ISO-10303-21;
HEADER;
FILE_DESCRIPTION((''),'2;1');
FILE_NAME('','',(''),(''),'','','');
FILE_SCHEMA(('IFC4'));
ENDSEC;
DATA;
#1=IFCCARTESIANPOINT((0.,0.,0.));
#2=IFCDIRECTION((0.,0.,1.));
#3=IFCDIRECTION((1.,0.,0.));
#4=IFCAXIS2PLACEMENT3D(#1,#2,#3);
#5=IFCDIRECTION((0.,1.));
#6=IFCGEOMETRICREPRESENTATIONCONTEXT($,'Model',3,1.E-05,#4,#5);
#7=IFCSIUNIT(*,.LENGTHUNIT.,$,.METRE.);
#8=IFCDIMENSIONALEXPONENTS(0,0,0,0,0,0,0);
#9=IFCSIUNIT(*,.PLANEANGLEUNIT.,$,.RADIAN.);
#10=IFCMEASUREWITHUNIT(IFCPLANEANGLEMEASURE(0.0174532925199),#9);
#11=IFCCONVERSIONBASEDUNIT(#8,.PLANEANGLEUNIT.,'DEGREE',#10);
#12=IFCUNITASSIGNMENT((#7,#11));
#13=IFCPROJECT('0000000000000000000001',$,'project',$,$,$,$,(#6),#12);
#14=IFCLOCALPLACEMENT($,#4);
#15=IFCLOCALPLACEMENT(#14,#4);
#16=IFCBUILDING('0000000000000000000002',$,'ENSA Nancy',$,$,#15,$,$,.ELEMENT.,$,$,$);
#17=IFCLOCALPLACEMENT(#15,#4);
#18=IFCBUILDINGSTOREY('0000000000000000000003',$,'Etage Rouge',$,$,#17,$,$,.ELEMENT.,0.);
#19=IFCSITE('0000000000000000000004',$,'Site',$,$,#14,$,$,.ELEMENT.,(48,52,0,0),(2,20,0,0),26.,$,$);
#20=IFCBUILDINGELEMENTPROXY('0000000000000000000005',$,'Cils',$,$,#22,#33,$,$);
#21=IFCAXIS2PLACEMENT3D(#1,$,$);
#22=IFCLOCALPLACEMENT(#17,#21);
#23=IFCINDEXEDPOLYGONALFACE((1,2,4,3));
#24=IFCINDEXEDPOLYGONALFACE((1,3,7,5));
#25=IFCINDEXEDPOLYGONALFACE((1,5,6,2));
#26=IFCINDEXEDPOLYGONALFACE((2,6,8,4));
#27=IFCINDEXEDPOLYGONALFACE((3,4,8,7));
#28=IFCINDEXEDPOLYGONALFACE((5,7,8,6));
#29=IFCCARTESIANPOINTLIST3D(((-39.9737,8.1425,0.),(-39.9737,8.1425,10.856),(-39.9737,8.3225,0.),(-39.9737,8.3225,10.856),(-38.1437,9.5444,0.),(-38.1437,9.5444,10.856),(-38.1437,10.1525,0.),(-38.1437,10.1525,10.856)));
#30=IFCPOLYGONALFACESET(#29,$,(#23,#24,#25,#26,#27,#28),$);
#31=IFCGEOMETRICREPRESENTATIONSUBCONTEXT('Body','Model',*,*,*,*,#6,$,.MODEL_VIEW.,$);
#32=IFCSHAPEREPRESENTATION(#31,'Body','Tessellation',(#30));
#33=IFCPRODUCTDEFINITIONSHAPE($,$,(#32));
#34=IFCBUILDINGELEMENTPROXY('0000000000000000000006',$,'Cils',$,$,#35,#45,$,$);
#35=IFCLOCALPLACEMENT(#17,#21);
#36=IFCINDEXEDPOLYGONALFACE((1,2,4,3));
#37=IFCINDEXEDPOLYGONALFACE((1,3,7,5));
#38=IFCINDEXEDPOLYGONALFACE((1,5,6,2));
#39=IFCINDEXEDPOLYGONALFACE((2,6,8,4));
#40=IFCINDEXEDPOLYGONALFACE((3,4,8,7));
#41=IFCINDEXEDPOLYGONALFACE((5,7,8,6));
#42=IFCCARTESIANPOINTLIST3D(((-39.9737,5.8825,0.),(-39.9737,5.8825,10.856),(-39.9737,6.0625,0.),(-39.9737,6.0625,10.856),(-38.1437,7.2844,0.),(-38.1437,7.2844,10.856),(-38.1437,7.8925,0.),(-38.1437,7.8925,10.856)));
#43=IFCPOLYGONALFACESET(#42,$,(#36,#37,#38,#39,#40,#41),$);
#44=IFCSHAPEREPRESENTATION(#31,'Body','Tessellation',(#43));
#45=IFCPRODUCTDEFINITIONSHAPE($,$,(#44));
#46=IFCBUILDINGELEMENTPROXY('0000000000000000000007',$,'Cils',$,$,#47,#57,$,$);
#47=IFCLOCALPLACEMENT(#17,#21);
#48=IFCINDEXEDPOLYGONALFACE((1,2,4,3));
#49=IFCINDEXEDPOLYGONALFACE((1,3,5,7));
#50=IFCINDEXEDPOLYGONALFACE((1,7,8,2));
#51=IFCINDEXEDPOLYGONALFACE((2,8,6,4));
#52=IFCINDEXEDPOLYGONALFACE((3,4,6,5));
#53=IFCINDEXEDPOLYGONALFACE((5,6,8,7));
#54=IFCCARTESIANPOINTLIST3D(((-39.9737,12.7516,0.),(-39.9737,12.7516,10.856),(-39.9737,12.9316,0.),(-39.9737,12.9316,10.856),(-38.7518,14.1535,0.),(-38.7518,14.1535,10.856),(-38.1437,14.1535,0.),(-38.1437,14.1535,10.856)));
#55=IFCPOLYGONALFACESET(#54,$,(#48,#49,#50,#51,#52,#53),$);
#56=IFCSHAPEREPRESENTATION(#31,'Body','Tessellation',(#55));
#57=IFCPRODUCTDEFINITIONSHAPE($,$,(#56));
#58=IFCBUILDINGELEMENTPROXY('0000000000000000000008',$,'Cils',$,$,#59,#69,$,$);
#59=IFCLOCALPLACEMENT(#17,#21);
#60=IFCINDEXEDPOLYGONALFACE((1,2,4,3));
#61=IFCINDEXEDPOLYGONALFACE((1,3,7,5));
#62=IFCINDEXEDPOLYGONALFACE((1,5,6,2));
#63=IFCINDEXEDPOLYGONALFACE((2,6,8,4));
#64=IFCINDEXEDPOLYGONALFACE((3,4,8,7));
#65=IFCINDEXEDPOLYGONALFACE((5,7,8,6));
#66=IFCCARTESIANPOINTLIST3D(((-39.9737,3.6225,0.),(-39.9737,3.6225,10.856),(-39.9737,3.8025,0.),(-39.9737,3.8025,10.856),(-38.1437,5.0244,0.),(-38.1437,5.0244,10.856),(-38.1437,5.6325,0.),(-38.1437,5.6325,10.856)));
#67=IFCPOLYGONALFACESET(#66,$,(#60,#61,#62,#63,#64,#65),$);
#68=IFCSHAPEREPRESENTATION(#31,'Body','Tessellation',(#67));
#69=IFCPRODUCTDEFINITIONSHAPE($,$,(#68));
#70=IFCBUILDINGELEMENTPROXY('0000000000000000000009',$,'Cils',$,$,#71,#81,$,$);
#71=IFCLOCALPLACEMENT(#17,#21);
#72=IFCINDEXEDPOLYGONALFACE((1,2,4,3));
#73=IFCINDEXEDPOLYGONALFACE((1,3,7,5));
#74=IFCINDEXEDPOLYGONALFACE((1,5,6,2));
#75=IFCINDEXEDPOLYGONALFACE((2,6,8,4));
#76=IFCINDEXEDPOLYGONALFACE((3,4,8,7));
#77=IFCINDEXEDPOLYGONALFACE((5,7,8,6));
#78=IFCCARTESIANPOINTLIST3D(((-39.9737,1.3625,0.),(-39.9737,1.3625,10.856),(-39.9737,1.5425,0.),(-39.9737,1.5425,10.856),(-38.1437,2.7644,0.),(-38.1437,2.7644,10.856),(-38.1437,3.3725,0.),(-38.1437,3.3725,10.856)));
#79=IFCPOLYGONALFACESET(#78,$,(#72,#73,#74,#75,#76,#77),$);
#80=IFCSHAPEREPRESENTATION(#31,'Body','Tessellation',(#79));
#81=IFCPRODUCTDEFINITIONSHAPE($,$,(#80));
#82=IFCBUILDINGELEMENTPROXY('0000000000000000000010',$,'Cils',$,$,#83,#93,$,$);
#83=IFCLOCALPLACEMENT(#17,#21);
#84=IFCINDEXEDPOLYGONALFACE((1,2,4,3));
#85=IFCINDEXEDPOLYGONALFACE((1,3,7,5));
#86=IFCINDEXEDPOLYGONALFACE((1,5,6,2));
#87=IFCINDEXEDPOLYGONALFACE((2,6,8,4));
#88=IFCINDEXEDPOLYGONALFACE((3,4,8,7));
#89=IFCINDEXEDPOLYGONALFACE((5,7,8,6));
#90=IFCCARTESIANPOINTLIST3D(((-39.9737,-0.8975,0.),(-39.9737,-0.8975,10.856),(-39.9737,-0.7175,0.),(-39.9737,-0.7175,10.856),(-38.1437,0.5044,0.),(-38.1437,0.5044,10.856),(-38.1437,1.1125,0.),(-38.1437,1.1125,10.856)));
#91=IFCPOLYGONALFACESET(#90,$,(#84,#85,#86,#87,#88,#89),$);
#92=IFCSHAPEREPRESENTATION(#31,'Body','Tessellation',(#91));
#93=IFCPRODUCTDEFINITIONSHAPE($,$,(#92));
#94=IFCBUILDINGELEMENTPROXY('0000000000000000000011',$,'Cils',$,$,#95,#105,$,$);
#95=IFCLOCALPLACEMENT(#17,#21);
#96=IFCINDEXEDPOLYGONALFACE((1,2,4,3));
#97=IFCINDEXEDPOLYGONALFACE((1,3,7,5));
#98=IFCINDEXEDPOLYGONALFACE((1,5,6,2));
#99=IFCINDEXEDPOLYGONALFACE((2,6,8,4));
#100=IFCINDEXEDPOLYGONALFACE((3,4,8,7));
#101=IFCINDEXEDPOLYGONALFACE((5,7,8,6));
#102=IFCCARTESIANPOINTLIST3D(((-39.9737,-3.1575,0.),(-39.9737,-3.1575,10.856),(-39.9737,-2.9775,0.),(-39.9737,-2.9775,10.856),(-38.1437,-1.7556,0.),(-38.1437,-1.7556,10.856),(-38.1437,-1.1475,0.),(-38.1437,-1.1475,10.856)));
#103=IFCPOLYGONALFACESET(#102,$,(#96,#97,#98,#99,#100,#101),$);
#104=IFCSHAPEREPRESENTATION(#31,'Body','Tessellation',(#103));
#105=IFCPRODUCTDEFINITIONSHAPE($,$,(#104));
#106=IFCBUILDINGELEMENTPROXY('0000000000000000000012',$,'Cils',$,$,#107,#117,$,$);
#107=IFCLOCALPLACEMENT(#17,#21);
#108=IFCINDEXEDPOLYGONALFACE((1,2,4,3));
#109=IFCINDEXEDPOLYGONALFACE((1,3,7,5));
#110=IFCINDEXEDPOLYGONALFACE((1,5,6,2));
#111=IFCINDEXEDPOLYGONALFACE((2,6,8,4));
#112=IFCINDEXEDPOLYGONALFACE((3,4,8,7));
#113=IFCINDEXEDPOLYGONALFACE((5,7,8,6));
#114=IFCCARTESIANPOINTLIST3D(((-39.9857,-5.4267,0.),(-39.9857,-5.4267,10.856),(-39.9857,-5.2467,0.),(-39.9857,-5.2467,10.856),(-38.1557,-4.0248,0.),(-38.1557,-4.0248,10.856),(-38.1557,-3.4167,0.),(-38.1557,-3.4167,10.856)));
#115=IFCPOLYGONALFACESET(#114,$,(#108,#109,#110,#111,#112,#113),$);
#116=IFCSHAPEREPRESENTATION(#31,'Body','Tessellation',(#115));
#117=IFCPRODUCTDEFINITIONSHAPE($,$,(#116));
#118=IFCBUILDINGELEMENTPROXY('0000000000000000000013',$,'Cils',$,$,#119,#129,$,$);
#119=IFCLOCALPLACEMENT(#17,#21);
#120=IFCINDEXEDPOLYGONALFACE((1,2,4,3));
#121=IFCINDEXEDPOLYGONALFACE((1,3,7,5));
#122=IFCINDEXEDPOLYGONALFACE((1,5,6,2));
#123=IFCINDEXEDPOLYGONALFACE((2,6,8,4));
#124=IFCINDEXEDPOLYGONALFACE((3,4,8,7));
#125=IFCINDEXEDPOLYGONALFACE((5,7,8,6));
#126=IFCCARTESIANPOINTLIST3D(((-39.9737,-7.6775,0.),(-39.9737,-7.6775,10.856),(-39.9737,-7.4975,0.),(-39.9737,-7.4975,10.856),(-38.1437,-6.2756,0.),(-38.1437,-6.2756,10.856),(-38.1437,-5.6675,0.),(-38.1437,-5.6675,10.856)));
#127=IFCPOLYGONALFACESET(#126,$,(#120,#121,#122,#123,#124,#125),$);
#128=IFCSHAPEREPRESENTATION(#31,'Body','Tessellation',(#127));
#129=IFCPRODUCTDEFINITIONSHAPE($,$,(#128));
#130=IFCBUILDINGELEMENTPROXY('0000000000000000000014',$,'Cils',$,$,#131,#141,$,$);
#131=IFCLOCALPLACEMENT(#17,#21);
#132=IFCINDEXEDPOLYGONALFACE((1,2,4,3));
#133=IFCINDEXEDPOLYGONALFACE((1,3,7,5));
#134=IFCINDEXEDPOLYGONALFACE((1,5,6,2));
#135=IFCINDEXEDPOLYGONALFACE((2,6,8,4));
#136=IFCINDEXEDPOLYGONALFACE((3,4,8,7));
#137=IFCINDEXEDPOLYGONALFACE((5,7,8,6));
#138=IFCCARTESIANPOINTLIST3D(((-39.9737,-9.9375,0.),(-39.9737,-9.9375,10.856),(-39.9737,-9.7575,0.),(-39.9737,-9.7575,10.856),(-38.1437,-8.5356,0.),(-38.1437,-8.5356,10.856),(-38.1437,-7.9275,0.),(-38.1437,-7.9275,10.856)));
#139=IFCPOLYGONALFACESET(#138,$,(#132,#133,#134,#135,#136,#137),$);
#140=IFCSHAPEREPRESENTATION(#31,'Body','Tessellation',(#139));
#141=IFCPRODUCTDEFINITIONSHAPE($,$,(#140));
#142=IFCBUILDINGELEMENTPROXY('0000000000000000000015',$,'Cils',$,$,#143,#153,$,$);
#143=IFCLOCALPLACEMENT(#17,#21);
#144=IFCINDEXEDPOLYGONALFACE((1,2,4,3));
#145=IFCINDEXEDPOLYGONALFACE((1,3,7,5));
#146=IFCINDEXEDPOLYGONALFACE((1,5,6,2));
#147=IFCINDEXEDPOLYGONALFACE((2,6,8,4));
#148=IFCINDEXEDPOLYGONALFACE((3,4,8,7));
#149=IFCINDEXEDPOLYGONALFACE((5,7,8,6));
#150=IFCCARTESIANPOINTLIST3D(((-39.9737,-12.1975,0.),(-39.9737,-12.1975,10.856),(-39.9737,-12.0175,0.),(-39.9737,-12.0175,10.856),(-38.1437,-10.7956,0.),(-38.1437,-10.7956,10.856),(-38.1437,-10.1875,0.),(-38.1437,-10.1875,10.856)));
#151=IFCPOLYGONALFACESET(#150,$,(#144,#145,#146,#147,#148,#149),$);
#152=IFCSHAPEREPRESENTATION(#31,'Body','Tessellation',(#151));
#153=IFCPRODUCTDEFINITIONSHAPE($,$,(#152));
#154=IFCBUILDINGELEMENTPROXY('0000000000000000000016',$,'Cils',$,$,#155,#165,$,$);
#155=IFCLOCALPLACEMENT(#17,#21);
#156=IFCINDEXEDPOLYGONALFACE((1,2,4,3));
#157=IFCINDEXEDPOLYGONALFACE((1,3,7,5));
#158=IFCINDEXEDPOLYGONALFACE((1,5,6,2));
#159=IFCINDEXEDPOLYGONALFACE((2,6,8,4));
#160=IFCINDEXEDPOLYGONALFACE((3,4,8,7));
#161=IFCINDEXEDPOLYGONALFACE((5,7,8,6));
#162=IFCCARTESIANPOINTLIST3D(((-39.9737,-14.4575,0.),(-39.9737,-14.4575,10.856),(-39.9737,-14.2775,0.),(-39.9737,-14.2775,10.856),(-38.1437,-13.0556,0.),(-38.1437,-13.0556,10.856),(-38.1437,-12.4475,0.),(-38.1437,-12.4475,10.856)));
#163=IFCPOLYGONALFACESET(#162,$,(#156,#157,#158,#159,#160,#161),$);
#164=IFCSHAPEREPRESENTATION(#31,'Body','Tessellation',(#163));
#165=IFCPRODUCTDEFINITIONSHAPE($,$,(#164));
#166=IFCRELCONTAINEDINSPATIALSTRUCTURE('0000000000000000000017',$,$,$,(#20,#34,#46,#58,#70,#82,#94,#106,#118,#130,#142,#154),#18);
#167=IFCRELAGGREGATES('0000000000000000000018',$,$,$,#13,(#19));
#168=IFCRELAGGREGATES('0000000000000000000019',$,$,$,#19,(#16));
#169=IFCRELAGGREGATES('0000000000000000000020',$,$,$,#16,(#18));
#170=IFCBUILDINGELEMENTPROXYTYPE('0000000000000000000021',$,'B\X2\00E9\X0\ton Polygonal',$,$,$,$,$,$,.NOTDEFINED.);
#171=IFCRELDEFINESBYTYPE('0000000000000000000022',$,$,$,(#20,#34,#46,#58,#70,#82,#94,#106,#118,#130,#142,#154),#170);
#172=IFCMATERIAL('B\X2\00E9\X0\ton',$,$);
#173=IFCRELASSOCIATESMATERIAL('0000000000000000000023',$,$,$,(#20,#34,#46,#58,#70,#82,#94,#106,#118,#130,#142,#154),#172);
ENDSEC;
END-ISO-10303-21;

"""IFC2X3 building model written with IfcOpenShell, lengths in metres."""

from ifc_helpers import new_model, entity, si_unit, converted_unit, direction, frame, origin_with_axes, place, context, subcontext, project, spatial, polyline, outline, extrude, material, type_object, element, save


model = new_model("IFC2X3")

# Units and contexts
model_context = context("Model", 3, precision=1e-05, world=origin_with_axes(), true_north=direction((0.0, 1.0)))
body_context = subcontext(model_context, "Body", "Model", "MODEL_VIEW")
ifc_project = project(units=[si_unit("LENGTHUNIT", "METRE"), converted_unit("PLANEANGLEUNIT", "DEGREE", entity("IfcPlaneAngleMeasure", 0.0174532925199), si_unit("PLANEANGLEUNIT", "RADIAN"), dimensions=[0, 0, 0, 0, 0, 0, 0])], contexts=[model_context])

# Site, building, storey
site_placement = place(None, origin_with_axes())
site = spatial("IfcSite", under=ifc_project, at=site_placement, Name="Site", CompositionType="ELEMENT", RefLatitude=(48, 52, 0, 0), RefLongitude=(2, 20, 0, 0), RefElevation=26.0)
building_placement = place(site_placement, origin_with_axes())
building = spatial("IfcBuilding", under=site, at=building_placement, Name="ENSA Nancy", CompositionType="ELEMENT")
storey_placement = place(building_placement, origin_with_axes())
storey = spatial("IfcBuildingStorey", under=building, at=storey_placement, Name="Etage Rouge", CompositionType="ELEMENT", Elevation=0.0)

# Shared definitions
ifc_material = material(Name="Béton")

# Building element proxies
building_element_proxy_type = type_object("IfcBuildingElementProxyType", Name="Béton Polygonal", PredefinedType="NOTDEFINED")
for number, where, z_axis, x_axis, name in (
    (1, (-38.1437, 10.1525, 0.0), (0.0, 0.0, 1.0), (-0.707107, -0.707107, 0.0), "Cils"),
    (2, (-38.1437, 7.8925, 0.0), (0.0, 0.0, 1.0), (-0.707107, -0.707107, 0.0), "Cils"),
):
    element("IfcBuildingElementProxy", number, at=place(storey_placement, frame(where, z_axis=z_axis, x_axis=x_axis)), inside=storey, type_object=building_element_proxy_type, material=ifc_material, Name=name, context=body_context, shape_type="SweptSolid", body=[
        extrude(outline(polyline([(0.0, 0.0), (2.588, 0.0), (2.7153, 0.1273), (0.43, 0.43), (0.0, 0.0)])), origin_with_axes(), (0.0, 0.0, 1.0), 10.856),
    ])
proxy_placement = place(storey_placement, frame((-39.9737, 12.9316, 0.0), z_axis=(0.0, 0.0, 1.0), x_axis=(0.0, -1.0, 0.0)))
element("IfcBuildingElementProxy", 3, at=proxy_placement, inside=storey, type_object=building_element_proxy_type, material=ifc_material, Name="Cils", context=body_context, shape_type="SweptSolid", body=[
    extrude(outline(polyline([(0.0, 0.0), (0.18, 0.0), (-1.2219, 1.83), (-1.2219, 1.2219), (0.0, 0.0)])), origin_with_axes(), (0.0, 0.0, 1.0), 10.856),
])
for number, where, z_axis, x_axis, name in (
    (4, (-38.1437, 5.6325, 0.0), (0.0, 0.0, 1.0), (-0.707107, -0.707107, 0.0), "Cils"),
    (5, (-38.1437, 3.3725, 0.0), (0.0, 0.0, 1.0), (-0.707107, -0.707107, 0.0), "Cils"),
    (6, (-38.1437, 1.1125, 0.0), (0.0, 0.0, 1.0), (-0.707107, -0.707107, 0.0), "Cils"),
    (7, (-38.1437, -1.1475, 0.0), (0.0, 0.0, 1.0), (-0.707107, -0.707107, 0.0), "Cils"),
    (8, (-38.1557, -3.4167, 0.0), (0.0, 0.0, 1.0), (-0.707107, -0.707107, 0.0), "Cils"),
    (9, (-38.1437, -5.6675, 0.0), (0.0, 0.0, 1.0), (-0.707107, -0.707107, 0.0), "Cils"),
    (10, (-38.1437, -7.9275, 0.0), (0.0, 0.0, 1.0), (-0.707107, -0.707107, 0.0), "Cils"),
    (11, (-38.1437, -10.1875, 0.0), (0.0, 0.0, 1.0), (-0.707107, -0.707107, 0.0), "Cils"),
    (12, (-38.1437, -12.4475, 0.0), (0.0, 0.0, 1.0), (-0.707107, -0.707107, 0.0), "Cils"),
):
    element("IfcBuildingElementProxy", number, at=place(storey_placement, frame(where, z_axis=z_axis, x_axis=x_axis)), inside=storey, type_object=building_element_proxy_type, material=ifc_material, Name=name, context=body_context, shape_type="SweptSolid", body=[
        extrude(outline(polyline([(0.0, 0.0), (2.588, 0.0), (2.7153, 0.1273), (0.43, 0.43), (0.0, 0.0)])), origin_with_axes(), (0.0, 0.0, 1.0), 10.856),
    ])

save(model, "model.ifc")
